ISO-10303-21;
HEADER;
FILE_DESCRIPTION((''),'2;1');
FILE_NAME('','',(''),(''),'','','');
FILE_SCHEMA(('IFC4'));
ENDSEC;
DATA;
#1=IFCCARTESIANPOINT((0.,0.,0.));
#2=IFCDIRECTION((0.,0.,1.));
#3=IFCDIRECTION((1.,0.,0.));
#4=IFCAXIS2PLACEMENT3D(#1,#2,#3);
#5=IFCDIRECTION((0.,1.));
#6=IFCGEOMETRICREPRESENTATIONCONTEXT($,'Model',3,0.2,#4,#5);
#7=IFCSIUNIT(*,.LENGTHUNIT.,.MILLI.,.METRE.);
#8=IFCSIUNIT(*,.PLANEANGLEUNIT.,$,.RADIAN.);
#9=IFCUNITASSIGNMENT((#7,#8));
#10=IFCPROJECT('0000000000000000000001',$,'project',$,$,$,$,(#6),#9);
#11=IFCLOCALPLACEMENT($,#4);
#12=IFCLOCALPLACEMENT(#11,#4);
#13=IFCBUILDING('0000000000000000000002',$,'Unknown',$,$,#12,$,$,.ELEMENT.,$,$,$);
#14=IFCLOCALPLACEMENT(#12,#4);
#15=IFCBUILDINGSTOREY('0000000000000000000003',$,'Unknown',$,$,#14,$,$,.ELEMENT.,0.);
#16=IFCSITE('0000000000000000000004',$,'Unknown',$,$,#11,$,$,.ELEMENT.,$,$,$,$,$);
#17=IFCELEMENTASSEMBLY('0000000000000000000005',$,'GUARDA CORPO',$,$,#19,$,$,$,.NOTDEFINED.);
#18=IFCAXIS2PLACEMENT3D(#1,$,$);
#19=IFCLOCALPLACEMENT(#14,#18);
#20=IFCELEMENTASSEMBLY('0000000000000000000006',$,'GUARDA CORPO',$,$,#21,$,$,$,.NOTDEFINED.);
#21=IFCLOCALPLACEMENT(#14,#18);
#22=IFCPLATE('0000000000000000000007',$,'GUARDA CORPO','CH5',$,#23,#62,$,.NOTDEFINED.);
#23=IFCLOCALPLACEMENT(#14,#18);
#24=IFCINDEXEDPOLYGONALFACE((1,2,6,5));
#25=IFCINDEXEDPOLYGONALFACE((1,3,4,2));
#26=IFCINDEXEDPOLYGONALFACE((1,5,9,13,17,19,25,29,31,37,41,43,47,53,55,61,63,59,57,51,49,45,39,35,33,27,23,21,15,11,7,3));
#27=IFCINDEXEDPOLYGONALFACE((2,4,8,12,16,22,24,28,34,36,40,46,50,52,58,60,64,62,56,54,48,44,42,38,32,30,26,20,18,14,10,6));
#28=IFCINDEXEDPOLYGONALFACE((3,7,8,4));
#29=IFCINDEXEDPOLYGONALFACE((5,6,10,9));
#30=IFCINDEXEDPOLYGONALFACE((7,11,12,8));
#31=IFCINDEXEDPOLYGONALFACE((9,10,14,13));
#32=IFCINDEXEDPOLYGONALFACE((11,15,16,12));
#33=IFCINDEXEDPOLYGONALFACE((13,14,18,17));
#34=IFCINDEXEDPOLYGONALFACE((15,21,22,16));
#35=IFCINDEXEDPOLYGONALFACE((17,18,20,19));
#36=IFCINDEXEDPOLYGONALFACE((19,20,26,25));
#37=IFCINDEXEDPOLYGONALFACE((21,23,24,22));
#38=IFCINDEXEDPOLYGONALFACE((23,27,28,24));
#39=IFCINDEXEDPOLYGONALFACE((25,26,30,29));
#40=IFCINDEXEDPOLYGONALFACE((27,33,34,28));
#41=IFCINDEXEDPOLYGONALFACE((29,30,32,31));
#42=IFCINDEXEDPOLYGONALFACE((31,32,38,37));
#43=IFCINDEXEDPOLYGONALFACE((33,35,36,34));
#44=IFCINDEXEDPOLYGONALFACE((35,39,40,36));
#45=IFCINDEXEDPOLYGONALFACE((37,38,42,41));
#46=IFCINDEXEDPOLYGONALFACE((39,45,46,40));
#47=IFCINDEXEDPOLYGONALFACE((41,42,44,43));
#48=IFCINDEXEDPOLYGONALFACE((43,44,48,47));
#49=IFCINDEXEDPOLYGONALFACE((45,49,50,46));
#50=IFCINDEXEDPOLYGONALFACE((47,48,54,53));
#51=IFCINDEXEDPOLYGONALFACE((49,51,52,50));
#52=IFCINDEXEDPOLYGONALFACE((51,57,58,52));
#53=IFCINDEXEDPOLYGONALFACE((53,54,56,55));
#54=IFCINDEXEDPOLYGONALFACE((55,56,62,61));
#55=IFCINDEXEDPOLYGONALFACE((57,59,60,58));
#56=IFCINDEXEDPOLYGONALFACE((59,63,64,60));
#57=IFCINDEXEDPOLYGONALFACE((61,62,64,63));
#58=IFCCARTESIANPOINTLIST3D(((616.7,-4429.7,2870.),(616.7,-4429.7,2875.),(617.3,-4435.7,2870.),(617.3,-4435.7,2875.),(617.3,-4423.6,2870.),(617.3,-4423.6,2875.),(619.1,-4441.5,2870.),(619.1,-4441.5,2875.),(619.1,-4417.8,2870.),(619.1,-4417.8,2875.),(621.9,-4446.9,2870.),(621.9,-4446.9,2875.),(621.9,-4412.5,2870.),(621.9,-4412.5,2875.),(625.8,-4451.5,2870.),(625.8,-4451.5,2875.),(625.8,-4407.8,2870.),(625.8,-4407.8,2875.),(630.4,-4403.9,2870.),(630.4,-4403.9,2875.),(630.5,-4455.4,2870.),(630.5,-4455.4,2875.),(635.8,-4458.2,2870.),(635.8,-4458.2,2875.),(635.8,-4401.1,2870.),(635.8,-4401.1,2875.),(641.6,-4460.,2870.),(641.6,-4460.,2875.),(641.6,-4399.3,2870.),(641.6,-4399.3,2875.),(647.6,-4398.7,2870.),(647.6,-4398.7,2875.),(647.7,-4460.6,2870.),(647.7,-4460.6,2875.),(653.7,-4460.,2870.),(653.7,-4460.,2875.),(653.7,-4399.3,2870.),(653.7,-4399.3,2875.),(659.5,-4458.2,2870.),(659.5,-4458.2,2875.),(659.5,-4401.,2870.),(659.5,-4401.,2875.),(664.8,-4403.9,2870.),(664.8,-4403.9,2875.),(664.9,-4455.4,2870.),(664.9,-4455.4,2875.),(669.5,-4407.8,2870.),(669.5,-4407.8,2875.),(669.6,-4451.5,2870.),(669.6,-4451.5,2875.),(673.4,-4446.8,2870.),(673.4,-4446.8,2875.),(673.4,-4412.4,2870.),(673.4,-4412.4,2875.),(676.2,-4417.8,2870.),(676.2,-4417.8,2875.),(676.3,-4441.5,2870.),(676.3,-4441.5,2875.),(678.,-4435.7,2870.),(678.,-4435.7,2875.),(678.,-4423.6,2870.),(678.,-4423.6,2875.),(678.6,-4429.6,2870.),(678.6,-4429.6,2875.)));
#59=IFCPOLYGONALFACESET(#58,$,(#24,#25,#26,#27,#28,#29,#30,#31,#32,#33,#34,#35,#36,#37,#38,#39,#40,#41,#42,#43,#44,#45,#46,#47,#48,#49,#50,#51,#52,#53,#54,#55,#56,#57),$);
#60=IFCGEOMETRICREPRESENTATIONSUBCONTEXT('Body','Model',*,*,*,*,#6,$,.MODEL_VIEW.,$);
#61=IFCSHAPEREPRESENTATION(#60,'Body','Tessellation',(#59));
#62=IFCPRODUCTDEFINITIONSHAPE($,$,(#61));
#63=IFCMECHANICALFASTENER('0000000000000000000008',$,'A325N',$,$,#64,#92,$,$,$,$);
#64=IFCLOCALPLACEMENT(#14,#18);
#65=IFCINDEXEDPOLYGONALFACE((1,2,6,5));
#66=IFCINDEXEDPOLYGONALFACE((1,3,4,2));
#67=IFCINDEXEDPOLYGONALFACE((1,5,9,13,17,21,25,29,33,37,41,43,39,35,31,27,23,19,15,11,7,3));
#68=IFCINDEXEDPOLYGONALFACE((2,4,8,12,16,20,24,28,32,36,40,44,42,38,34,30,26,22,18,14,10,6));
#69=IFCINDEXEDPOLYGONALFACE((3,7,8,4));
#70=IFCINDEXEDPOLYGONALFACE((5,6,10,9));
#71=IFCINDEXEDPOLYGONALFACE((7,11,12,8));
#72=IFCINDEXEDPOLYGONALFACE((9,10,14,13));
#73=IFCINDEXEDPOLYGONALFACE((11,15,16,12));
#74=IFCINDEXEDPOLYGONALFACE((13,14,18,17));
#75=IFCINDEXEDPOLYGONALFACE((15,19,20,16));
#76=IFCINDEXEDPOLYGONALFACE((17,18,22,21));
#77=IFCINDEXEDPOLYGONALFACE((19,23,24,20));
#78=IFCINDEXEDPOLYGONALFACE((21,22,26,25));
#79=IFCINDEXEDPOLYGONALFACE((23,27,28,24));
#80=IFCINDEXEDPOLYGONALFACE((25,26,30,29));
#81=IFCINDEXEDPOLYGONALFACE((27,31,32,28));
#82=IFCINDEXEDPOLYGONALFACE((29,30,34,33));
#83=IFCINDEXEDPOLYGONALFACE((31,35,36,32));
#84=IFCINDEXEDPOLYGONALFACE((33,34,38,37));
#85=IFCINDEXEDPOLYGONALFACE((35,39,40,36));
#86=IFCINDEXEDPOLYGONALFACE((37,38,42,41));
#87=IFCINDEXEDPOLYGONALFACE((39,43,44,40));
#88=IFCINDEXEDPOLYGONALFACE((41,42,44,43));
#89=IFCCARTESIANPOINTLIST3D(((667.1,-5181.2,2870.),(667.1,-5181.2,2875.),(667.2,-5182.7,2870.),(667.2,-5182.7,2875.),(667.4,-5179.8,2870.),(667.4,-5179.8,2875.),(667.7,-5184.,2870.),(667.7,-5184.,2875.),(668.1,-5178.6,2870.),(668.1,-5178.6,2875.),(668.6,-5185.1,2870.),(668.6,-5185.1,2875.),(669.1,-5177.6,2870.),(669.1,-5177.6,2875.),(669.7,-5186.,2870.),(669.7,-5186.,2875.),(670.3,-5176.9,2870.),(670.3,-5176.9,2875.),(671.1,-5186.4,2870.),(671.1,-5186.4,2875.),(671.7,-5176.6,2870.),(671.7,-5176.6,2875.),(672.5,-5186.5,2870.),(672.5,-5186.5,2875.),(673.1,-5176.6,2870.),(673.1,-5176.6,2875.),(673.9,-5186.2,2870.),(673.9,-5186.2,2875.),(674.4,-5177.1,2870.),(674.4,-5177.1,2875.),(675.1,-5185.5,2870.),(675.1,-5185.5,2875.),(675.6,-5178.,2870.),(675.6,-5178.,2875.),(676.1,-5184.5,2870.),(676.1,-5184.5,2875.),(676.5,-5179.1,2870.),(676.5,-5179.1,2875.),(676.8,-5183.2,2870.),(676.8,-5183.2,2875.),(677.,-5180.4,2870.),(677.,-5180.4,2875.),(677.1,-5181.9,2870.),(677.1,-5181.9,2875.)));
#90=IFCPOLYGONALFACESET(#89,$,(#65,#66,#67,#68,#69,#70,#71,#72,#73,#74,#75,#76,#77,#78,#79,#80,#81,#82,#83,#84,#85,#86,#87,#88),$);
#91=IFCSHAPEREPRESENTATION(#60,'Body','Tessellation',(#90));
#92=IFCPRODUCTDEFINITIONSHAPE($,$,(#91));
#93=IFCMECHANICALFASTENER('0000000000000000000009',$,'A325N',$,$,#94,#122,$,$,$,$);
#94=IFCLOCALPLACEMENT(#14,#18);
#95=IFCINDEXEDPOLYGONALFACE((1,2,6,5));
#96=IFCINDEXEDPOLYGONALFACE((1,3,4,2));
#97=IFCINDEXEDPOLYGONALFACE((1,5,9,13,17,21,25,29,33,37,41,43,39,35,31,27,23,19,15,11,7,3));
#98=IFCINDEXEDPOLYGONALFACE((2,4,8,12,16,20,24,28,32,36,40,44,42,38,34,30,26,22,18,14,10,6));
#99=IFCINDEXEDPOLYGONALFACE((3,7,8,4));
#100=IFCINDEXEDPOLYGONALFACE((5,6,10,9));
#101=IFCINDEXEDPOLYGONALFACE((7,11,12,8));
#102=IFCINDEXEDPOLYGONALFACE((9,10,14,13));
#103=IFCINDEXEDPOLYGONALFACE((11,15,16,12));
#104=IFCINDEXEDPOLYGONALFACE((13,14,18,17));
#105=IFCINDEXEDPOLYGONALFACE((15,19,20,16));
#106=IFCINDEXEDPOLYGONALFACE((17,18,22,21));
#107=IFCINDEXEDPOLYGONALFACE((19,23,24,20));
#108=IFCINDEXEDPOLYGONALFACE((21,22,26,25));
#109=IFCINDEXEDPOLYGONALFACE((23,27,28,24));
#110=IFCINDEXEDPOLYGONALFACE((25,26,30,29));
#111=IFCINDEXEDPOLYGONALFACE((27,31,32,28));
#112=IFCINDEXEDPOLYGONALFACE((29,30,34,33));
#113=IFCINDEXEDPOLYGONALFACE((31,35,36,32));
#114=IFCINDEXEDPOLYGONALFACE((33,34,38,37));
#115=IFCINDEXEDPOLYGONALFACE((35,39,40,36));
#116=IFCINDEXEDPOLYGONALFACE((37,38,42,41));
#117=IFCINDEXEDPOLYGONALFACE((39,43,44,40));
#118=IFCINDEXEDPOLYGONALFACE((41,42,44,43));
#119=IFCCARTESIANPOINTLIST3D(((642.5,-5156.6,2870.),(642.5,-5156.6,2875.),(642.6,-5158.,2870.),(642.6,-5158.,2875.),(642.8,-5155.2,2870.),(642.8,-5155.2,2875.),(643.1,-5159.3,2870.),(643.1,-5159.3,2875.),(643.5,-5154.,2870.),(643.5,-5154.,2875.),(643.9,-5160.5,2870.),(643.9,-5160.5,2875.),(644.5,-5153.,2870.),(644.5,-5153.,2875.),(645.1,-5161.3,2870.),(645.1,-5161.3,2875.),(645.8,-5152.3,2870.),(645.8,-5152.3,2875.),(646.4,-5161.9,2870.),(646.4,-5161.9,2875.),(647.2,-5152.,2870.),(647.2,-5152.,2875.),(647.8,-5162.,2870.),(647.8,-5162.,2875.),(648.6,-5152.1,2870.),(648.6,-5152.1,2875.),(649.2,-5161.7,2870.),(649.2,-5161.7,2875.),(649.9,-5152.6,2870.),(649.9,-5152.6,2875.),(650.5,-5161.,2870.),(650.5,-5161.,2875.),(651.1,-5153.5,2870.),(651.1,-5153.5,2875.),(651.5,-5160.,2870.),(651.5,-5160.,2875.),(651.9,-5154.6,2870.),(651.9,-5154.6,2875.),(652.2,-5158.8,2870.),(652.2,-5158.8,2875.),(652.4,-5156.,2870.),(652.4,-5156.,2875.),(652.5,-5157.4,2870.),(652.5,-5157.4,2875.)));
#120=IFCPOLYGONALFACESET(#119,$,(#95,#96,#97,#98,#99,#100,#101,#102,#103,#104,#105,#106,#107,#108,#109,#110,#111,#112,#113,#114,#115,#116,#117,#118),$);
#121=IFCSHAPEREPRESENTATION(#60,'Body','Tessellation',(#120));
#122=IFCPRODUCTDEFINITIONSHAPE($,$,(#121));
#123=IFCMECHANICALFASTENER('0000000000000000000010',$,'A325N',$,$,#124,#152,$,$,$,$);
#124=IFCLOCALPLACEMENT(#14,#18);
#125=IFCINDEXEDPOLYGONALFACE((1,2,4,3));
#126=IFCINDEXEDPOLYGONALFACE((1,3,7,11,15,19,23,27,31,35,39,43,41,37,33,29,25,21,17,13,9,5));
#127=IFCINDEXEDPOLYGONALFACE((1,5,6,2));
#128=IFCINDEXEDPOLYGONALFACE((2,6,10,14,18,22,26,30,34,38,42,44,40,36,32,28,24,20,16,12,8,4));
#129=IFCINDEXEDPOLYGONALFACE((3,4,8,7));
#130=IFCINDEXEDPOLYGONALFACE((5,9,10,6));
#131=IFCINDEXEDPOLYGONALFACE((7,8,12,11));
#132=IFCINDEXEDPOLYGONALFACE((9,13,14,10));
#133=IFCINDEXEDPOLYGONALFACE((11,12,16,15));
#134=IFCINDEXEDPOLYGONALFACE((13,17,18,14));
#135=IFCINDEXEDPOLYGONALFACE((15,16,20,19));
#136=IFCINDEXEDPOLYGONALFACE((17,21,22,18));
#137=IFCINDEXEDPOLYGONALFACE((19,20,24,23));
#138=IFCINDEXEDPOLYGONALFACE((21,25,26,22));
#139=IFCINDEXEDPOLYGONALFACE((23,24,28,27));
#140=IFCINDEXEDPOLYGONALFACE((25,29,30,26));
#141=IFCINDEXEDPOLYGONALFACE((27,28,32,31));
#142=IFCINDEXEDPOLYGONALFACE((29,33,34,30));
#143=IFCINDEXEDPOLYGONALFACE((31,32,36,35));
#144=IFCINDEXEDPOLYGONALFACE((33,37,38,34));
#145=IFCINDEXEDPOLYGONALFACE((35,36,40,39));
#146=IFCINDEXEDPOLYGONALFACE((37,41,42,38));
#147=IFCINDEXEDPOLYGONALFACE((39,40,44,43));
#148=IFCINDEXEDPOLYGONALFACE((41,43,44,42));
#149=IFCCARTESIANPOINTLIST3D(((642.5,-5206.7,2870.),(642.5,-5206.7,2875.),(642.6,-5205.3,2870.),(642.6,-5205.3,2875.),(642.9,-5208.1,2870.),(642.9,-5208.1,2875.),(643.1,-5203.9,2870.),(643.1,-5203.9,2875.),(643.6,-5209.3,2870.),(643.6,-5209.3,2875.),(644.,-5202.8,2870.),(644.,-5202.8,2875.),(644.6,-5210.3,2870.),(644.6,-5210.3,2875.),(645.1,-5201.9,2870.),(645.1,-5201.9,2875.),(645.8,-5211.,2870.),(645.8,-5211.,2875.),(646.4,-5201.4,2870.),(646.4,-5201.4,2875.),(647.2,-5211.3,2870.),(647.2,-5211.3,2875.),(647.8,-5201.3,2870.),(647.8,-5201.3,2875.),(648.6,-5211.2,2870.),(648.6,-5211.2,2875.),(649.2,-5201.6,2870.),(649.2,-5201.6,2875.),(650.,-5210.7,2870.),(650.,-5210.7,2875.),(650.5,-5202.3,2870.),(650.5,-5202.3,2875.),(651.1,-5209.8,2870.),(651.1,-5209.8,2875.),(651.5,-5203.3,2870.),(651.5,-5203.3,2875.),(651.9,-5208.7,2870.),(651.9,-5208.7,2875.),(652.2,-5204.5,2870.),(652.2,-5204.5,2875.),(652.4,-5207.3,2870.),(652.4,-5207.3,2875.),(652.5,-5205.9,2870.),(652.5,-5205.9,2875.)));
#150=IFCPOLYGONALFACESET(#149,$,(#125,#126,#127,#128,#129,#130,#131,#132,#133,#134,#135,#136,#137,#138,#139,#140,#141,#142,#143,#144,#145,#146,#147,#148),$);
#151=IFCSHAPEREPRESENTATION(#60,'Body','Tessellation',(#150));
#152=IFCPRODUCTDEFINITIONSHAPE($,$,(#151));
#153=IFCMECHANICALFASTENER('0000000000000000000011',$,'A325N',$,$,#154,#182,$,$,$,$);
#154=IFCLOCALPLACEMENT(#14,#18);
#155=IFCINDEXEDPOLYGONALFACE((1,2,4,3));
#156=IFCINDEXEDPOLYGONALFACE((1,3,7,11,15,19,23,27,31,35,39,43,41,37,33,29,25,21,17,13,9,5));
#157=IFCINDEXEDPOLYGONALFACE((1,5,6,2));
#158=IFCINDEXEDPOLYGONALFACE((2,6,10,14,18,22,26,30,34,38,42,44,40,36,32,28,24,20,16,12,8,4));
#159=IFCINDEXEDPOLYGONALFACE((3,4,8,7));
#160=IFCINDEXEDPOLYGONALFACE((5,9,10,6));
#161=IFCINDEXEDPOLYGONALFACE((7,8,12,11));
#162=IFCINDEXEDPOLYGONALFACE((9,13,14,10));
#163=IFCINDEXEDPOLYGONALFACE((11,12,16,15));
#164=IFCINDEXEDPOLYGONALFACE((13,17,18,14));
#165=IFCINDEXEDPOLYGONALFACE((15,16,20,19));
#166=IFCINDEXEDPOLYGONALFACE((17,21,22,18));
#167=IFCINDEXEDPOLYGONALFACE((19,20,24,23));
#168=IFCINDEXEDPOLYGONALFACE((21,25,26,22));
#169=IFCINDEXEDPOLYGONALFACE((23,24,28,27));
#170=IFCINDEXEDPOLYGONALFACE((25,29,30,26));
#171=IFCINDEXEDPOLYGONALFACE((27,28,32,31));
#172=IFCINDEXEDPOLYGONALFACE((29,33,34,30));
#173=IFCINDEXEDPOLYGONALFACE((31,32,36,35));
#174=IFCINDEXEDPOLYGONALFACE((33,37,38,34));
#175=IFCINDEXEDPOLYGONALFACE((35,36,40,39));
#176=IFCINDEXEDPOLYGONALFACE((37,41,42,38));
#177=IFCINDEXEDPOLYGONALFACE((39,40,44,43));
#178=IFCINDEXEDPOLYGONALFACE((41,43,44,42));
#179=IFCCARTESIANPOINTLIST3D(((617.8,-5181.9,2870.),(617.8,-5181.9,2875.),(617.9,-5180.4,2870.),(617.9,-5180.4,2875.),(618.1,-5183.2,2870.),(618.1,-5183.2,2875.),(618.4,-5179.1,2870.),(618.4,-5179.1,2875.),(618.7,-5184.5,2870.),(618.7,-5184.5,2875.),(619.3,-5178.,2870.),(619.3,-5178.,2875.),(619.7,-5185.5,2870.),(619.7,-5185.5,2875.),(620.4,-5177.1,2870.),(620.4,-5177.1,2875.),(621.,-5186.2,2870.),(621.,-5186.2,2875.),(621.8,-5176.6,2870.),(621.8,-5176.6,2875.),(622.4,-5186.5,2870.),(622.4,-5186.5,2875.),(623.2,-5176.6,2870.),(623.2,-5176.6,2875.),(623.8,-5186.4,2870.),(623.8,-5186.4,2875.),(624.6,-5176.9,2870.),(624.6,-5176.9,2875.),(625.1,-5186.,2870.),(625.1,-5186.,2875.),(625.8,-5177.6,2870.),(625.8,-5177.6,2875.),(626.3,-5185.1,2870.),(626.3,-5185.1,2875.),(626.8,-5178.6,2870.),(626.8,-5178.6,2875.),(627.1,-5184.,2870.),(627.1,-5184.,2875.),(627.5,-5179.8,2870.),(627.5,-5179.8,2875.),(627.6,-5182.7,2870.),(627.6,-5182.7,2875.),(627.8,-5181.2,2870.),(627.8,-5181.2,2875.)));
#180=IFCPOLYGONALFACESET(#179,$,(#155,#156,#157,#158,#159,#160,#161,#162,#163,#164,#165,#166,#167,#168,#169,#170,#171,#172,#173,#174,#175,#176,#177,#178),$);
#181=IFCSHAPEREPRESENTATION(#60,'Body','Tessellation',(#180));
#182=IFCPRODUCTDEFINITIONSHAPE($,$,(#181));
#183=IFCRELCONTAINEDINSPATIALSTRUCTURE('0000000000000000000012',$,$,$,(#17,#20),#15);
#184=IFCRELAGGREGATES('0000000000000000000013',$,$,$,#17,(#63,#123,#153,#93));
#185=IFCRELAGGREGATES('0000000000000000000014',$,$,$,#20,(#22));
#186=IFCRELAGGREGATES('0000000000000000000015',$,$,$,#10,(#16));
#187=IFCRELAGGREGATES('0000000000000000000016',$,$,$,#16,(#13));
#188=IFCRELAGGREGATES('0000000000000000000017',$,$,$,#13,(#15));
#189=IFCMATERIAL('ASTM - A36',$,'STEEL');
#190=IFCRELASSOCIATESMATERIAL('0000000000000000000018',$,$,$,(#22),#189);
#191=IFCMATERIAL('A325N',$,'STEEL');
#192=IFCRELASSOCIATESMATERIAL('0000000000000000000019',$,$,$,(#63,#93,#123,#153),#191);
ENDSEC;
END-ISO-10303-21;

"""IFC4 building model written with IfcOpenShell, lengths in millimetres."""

from ifc_helpers import new_model, si_unit, direction, frame, origin_with_axes, place, context, subcontext, project, spatial, line, arc, indexed_curve, outline, extrude, source, transform, mapped, material, element, aggregate, save


model = new_model("IFC4")

# Units and contexts
model_context = context("Model", 3, precision=0.2, world=origin_with_axes(), true_north=direction((0.0, 1.0)))
body_context = subcontext(model_context, "Body", "Model", "MODEL_VIEW")
ifc_project = project(units=[si_unit("LENGTHUNIT", "METRE", prefix="MILLI"), si_unit("PLANEANGLEUNIT", "RADIAN")], contexts=[model_context])

# Site, building, storey
site_placement = place(None, origin_with_axes())
site = spatial("IfcSite", under=ifc_project, at=site_placement, Name="Unknown", CompositionType="ELEMENT")
building_placement = place(site_placement, origin_with_axes())
building = spatial("IfcBuilding", under=site, at=building_placement, Name="Unknown", CompositionType="ELEMENT")
storey_placement = place(building_placement, origin_with_axes())
storey = spatial("IfcBuildingStorey", under=building, at=storey_placement, Name="Unknown", CompositionType="ELEMENT", Elevation=0.0)

# Element assemblies, plate
assembly_1_placement = place(storey_placement, frame((647.5, -5181.6, 2875.0), z_axis=(-0.000512, 1.0, -0.000003), x_axis=(0.000003, 0.000003, 1.0)))
assembly_1 = element("IfcElementAssembly", 1, at=assembly_1_placement, inside=storey, Name="GUARDA CORPO", PredefinedType="NOTDEFINED")
ifc_material_1 = material(Name="ASTM - A36", Category="STEEL")
assembly_2_placement = place(storey_placement, frame((2747.5, -4429.7, 3415.0), z_axis=(-0.000512, -1.0, -0.000003), x_axis=(0.000003, -0.000003, 1.0)))
assembly_2 = element("IfcElementAssembly", 2, at=assembly_2_placement, inside=storey, Name="GUARDA CORPO", PredefinedType="NOTDEFINED")
plate_1_placement = place(assembly_2_placement, frame((-542.5, 2130.2, 7.1), z_axis=(1.0, 0.000008, 0.0), x_axis=(0.000002, -0.291265, 0.956642)))
plate_1 = element("IfcPlate", 3, at=plate_1_placement, material=ifc_material_1, Name="GUARDA CORPO", Description="CH5", PredefinedType="NOTDEFINED", context=body_context, shape_type="SolidModel", body=[
    extrude(outline(indexed_curve([(0.0, 0.0), (6.1, 0.0), (12.0, 1.2), (17.6, 3.5), (22.7, 6.9), (27.0, 11.2), (30.3, 16.2), (32.7, 21.8), (33.8, 27.8), (33.8, 33.8), (32.7, 39.8), (30.3, 45.4), (27.0, 50.4), (22.7, 54.7), (17.6, 58.1), (12.0, 60.4), (6.1, 61.6), (0.0, 61.6), (-6.0, 60.4), (-11.6, 58.1), (-16.6, 54.7), (-20.9, 50.4), (-24.3, 45.4), (-26.6, 39.8), (-27.8, 33.8), (-27.8, 27.8), (-26.6, 21.8), (-24.3, 16.2), (-20.9, 11.2), (-16.6, 6.9), (-11.6, 3.5), (-6.0, 1.2)], segments=[line(1, 2, 3, 4, 5, 6, 7, 8, 9, 10, 11, 12, 13, 14, 15, 16, 17, 18, 19, 20, 21, 22, 23, 24, 25, 26, 27, 28, 29, 30, 31, 32, 1)])), frame((0.0, 0.0, 2.5), z_axis=(0.0, 0.0, 1.0), x_axis=(1.0, 0.0, 0.0)), (0.0, 0.0, -1.0), 5.0),
])

# Shared definitions
ifc_material_2 = material(Name="A325N", Category="STEEL")

# Mechanical fasteners
shared_shape_1 = source(origin_with_axes(), body_context, "Body", "SweptSolid", [
    extrude(outline(indexed_curve([(5.0, 0.0), (0.0, 5.0), (-5.0, 0.0), (0.0, -5.0)], segments=[arc(1, 2, 3), arc(3, 4, 1)])), frame((0.0, 0.0, 0.0), z_axis=(0.0, 0.0, -1.0), x_axis=(0.0, 1.0, 0.0)), (0.0, 0.0, 1.0), 5.0),
])
mechanical_fastener_1_placement = place(assembly_1_placement, frame((0.0, 24.5, 0.1), z_axis=(1.0, -0.000002, -0.000003), x_axis=(0.0, -0.881921, 0.471397)))
mechanical_fastener_1 = element("IfcMechanicalFastener", 4, at=mechanical_fastener_1_placement, material=ifc_material_2, Name="A325N", context=body_context, shape_type="MappedRepresentation", body=[
    mapped(shared_shape_1, transform((0.0, 0.0, 0.0))),
])
mechanical_fastener_2_placement = place(assembly_1_placement, frame((0.0, 0.0, 24.6), z_axis=(1.0, -0.000004, -0.000001), x_axis=(0.000001, 0.471416, -0.881911)))
mechanical_fastener_2 = element("IfcMechanicalFastener", 5, at=mechanical_fastener_2_placement, material=ifc_material_2, Name="A325N", context=body_context, shape_type="MappedRepresentation", body=[
    mapped(shared_shape_1, transform((0.0, 0.0, 0.0))),
])
shared_shape_2 = source(origin_with_axes(), body_context, "Body", "SweptSolid", [
    extrude(outline(indexed_curve([(5.0, 0.0), (0.0, 5.0), (-5.0, 0.0), (0.0, -5.0)], segments=[arc(1, 2, 3), arc(3, 4, 1)])), frame((0.0, 0.0, 0.0), z_axis=(0.0, 0.0, -1.0), x_axis=(0.0, 1.0, 0.0)), (0.0, 0.0, 1.0), 5.0),
])
mechanical_fastener_3_placement = place(assembly_1_placement, frame((0.0, 0.0, -24.7), z_axis=(1.0, -0.000004, -0.000004), x_axis=(0.000005, 0.471397, 0.881921)))
mechanical_fastener_3 = element("IfcMechanicalFastener", 6, at=mechanical_fastener_3_placement, material=ifc_material_2, Name="A325N", context=body_context, shape_type="MappedRepresentation", body=[
    mapped(shared_shape_2, transform((0.0, 0.0, 0.0))),
])
mechanical_fastener_4_placement = place(assembly_1_placement, frame((0.0, -24.8, 0.1), z_axis=(1.0, -0.000004, -0.000003), x_axis=(0.000005, 0.882404, 0.470493)))
mechanical_fastener_4 = element("IfcMechanicalFastener", 7, at=mechanical_fastener_4_placement, material=ifc_material_2, Name="A325N", context=body_context, shape_type="MappedRepresentation", body=[
    mapped(shared_shape_2, transform((0.0, 0.0, 0.0))),
])
aggregate(assembly_1, [mechanical_fastener_1, mechanical_fastener_3, mechanical_fastener_4, mechanical_fastener_2])
aggregate(assembly_2, [plate_1])

save(model, "model.ifc")
